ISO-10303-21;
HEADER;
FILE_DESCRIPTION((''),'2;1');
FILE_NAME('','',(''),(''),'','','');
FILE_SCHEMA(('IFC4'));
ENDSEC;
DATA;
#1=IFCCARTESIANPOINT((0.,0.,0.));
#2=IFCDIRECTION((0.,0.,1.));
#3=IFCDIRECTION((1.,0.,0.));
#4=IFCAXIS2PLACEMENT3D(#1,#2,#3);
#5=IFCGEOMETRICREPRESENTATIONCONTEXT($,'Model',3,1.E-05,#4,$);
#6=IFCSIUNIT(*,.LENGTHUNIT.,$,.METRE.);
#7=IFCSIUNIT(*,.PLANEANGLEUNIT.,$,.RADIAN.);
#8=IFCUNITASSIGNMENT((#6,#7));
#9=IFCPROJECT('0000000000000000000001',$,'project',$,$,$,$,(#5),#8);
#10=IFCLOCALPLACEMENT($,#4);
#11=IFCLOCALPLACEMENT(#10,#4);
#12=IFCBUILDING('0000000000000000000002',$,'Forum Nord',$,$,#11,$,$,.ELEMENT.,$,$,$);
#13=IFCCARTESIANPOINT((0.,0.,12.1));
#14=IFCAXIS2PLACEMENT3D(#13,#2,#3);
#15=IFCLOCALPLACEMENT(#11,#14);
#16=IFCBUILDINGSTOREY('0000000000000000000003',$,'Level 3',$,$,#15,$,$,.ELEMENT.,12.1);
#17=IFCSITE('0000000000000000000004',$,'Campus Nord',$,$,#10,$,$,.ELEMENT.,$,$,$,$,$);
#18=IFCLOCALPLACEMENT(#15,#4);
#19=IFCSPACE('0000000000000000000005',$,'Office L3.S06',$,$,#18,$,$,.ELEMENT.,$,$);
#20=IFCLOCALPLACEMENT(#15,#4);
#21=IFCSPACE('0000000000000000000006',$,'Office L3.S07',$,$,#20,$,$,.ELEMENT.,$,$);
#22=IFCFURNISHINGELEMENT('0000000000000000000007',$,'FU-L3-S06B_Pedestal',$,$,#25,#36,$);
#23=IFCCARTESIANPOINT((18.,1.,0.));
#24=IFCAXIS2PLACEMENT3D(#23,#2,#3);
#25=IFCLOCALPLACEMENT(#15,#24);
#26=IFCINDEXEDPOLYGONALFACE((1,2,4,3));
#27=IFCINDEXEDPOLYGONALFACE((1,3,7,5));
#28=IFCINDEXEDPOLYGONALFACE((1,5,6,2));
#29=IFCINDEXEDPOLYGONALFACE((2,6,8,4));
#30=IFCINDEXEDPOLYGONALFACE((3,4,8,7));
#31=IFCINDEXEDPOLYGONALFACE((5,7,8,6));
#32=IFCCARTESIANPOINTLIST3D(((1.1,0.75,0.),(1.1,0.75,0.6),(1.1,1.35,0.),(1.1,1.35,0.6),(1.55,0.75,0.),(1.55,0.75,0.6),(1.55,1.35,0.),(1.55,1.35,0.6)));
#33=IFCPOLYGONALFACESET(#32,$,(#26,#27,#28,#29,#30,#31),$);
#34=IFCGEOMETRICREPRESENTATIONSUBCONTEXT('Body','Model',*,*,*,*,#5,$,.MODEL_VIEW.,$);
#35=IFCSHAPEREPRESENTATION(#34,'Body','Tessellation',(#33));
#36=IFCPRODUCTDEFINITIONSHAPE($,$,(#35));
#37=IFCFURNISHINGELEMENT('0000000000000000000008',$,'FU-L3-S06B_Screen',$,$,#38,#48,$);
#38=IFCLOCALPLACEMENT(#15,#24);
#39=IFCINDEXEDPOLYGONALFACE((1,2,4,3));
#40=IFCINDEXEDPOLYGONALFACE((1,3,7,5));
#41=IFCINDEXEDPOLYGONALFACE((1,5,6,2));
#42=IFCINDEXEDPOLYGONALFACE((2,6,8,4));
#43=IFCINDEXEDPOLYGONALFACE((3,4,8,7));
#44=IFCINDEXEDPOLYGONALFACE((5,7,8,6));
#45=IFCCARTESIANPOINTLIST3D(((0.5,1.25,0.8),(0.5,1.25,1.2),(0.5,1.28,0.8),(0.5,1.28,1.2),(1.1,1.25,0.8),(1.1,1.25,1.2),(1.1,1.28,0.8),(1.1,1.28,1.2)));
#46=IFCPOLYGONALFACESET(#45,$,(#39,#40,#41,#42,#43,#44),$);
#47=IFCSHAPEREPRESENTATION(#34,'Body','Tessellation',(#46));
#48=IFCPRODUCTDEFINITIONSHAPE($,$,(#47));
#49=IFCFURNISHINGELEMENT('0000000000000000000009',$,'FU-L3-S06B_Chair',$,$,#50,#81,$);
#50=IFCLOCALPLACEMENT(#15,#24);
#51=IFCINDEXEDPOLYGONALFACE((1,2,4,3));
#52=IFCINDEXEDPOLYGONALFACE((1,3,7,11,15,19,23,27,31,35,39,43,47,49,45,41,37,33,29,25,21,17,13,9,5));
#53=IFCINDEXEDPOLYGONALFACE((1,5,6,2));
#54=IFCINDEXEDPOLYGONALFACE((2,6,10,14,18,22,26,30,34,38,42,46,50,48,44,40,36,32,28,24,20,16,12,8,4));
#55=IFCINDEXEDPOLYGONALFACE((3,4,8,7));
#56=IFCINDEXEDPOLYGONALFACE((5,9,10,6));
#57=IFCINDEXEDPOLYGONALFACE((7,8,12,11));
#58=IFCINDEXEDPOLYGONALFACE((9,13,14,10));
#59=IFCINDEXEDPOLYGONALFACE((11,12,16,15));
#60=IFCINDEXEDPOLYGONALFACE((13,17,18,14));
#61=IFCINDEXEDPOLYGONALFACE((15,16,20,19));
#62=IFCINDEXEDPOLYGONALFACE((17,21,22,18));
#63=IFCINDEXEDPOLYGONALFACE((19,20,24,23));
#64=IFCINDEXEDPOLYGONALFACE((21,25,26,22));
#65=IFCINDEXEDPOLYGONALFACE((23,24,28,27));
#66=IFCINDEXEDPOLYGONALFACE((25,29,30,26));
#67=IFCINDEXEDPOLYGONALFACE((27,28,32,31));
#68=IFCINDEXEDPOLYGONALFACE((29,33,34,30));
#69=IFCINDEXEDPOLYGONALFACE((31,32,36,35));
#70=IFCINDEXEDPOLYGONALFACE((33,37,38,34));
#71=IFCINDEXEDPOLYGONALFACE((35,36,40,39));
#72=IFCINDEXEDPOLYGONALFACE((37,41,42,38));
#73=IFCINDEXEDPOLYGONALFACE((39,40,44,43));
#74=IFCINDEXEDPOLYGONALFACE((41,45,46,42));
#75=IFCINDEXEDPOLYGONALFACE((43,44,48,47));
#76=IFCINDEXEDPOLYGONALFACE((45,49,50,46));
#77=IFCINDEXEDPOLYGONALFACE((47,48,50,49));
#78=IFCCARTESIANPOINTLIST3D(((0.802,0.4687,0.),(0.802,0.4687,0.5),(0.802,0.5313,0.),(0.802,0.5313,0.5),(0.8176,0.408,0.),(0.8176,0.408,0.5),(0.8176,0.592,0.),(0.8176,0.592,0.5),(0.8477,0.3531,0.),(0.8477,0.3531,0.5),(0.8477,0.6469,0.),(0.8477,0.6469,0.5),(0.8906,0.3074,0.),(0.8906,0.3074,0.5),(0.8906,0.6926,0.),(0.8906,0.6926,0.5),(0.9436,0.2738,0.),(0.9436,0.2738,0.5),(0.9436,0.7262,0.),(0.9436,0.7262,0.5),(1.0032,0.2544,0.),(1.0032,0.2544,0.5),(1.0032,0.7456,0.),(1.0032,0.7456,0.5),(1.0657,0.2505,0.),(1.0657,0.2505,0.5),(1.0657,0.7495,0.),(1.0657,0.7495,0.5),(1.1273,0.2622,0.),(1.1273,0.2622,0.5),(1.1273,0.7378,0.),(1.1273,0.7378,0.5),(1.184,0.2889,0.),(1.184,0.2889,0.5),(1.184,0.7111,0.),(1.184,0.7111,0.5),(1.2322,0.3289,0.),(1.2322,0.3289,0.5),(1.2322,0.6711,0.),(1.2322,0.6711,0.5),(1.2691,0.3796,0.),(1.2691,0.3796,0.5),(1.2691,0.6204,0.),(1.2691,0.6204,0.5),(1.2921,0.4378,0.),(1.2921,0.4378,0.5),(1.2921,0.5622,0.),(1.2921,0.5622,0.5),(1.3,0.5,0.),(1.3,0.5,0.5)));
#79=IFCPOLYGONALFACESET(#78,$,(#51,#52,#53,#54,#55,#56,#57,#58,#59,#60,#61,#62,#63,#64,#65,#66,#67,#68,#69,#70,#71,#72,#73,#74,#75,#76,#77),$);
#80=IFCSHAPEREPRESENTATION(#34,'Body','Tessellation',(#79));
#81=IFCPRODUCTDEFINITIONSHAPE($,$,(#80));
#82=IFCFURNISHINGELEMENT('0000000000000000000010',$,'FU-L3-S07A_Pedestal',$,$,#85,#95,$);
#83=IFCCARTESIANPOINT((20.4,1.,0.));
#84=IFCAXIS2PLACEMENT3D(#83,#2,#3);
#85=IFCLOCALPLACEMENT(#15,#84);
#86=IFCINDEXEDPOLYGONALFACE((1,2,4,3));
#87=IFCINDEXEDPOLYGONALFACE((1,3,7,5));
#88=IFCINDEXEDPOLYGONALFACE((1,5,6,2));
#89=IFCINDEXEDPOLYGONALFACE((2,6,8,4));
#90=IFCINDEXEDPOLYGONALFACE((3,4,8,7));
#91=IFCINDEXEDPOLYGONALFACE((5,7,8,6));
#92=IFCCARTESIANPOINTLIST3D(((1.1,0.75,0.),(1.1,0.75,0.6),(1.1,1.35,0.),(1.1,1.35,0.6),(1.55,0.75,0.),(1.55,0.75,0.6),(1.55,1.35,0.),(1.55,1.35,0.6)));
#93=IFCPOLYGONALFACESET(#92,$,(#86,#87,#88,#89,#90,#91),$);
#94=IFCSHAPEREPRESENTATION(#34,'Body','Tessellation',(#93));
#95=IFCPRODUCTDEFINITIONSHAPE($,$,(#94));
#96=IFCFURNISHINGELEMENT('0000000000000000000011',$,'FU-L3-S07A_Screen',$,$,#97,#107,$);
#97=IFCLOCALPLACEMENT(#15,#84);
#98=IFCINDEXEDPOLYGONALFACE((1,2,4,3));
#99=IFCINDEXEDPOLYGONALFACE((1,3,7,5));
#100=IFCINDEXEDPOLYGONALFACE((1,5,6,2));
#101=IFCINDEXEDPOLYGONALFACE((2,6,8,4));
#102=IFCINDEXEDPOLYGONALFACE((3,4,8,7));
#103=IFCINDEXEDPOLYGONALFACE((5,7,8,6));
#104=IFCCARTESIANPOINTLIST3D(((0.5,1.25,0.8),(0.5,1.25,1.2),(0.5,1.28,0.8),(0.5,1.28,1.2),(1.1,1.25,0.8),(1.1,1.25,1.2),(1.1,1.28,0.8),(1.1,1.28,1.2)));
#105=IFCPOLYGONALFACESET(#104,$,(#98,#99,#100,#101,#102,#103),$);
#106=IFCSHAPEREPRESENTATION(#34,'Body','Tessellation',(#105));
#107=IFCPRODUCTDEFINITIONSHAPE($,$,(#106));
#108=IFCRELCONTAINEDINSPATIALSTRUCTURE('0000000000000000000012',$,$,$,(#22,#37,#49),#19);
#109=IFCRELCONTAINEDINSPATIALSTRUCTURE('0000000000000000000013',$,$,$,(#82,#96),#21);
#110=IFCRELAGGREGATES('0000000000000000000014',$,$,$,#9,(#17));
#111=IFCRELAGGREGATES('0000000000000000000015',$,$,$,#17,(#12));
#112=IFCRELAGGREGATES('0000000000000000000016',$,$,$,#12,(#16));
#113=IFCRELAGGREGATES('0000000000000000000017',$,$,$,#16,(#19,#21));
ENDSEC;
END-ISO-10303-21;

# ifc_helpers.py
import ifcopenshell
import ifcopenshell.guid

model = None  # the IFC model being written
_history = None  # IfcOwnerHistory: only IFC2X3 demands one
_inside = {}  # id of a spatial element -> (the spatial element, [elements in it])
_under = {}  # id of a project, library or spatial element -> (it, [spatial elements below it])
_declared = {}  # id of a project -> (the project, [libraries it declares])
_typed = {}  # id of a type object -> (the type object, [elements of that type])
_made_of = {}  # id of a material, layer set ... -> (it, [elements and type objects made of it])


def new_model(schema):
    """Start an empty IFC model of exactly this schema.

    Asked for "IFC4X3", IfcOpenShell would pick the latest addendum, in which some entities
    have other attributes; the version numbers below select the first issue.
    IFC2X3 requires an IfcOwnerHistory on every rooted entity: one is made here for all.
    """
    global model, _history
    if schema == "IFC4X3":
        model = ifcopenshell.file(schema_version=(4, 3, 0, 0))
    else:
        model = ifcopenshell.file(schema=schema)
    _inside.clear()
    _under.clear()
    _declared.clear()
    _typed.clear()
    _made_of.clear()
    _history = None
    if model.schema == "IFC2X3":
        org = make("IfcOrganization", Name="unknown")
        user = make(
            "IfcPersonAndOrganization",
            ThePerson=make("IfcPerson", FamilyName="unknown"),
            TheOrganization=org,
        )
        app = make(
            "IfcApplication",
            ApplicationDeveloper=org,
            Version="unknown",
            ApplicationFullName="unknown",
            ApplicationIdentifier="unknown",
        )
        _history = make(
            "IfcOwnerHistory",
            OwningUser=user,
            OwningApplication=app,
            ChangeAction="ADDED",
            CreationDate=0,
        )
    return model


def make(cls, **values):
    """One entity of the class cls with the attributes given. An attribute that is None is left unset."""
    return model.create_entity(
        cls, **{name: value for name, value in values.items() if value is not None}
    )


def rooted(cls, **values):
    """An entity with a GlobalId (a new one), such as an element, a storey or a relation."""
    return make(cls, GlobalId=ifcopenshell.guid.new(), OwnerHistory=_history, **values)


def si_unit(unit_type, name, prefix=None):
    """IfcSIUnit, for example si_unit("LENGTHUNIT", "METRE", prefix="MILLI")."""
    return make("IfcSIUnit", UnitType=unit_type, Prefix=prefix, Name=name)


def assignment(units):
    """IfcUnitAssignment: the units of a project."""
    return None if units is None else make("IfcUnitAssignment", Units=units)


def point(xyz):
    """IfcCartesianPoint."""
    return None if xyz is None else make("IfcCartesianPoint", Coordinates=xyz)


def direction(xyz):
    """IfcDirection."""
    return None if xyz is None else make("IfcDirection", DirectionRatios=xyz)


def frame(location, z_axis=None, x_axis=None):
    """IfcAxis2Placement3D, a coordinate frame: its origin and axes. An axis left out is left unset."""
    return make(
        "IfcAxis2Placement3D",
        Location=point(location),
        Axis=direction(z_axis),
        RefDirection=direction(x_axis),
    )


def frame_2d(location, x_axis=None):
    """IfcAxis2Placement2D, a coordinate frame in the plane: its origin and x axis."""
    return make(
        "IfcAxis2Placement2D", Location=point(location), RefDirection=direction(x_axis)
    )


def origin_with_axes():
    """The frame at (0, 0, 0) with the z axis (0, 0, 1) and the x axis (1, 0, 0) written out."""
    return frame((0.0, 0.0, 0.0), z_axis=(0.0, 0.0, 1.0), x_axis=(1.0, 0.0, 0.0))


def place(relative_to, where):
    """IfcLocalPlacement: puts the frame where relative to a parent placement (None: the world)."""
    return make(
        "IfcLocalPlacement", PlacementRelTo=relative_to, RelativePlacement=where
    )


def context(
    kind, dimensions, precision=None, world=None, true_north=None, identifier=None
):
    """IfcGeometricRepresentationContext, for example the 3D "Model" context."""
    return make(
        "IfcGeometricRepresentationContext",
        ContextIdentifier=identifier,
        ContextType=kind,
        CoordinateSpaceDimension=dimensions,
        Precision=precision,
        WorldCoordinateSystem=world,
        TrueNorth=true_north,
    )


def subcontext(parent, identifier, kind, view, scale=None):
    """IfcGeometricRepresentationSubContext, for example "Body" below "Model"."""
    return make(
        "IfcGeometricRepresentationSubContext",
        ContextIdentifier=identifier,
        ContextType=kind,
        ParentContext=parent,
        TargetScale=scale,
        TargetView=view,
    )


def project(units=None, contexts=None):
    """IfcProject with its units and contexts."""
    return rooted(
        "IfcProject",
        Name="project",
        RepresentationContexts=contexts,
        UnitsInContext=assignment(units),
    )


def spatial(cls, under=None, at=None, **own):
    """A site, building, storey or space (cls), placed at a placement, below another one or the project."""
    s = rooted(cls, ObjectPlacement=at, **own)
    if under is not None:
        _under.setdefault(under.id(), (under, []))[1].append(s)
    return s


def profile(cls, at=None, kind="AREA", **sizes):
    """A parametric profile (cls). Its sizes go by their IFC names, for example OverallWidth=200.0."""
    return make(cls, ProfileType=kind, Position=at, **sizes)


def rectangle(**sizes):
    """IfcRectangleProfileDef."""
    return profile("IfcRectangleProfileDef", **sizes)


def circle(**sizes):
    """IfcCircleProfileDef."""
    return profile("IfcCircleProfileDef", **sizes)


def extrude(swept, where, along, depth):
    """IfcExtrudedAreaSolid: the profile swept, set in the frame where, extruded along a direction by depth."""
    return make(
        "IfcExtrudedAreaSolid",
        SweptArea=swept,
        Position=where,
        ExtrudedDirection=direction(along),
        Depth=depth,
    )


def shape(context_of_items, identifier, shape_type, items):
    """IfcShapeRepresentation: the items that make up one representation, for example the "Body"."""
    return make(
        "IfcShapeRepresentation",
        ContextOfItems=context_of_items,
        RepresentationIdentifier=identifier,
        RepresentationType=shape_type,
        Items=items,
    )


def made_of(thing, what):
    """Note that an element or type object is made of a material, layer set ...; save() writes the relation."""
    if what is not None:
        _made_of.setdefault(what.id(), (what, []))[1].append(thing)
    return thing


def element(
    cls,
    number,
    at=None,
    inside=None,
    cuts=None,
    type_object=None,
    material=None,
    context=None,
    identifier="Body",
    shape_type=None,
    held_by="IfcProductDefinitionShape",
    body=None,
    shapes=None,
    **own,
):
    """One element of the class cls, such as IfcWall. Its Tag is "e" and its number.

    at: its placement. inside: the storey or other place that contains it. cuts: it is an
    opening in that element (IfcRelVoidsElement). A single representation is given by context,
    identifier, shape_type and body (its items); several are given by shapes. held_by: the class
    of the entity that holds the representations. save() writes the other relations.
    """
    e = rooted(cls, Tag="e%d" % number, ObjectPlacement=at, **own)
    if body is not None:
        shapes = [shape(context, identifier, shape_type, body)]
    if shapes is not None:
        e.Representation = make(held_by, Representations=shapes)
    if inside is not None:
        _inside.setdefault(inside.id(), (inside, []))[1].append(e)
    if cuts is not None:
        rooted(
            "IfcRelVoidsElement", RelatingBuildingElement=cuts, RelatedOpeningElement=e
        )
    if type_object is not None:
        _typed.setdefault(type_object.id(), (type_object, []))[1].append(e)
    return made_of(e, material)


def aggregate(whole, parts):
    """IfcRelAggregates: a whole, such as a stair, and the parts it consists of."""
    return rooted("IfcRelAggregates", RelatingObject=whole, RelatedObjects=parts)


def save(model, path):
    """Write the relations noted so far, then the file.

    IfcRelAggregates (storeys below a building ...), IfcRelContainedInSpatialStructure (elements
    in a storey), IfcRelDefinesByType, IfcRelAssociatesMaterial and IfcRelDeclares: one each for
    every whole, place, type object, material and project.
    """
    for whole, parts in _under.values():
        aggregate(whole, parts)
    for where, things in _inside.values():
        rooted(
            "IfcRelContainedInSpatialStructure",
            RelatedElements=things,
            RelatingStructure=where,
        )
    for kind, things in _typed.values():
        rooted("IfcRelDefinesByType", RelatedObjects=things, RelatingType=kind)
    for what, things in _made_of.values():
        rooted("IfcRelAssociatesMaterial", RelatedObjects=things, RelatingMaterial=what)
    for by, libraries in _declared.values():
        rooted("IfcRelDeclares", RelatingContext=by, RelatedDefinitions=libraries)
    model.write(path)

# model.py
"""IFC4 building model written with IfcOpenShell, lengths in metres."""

from ifc_helpers import new_model, si_unit, frame, frame_2d, origin_with_axes, place, context, subcontext, project, spatial, rectangle, circle, extrude, element, save


model = new_model("IFC4")

# Units and contexts
model_context = context("Model", 3, precision=1e-05, world=origin_with_axes())
body_context = subcontext(model_context, "Body", "Model", "MODEL_VIEW")
ifc_project = project(units=[si_unit("LENGTHUNIT", "METRE"), si_unit("PLANEANGLEUNIT", "RADIAN")], contexts=[model_context])

# Site, building, storey
site_placement = place(None, origin_with_axes())
site = spatial("IfcSite", under=ifc_project, at=site_placement, Name="Campus Nord", CompositionType="ELEMENT")
building_placement = place(site_placement, origin_with_axes())
building = spatial("IfcBuilding", under=site, at=building_placement, Name="Forum Nord", CompositionType="ELEMENT")
storey_placement = place(building_placement, frame((0.0, 0.0, 12.1), z_axis=(0.0, 0.0, 1.0), x_axis=(1.0, 0.0, 0.0)))
storey = spatial("IfcBuildingStorey", under=building, at=storey_placement, Name="Level 3", CompositionType="ELEMENT", Elevation=12.1)

# Shared definitions
space_1_placement = place(storey_placement, origin_with_axes())
space_1 = spatial("IfcSpace", under=storey, at=space_1_placement, Name="Office L3.S06", CompositionType="ELEMENT")

# Furnishing elements
furnishing_1_placement = place(storey_placement, frame((18.0, 1.0, 0.0), z_axis=(0.0, 0.0, 1.0), x_axis=(1.0, 0.0, 0.0)))
element("IfcFurnishingElement", 1, at=furnishing_1_placement, inside=space_1, Name="FU-L3-S06B_Pedestal", context=body_context, shape_type="SweptSolid", body=[
    extrude(rectangle(XDim=0.45, YDim=0.6, at=frame_2d((1.325, 1.05), x_axis=(1.0, 0.0))), origin_with_axes(), (0.0, 0.0, 1.0), 0.6),
])
furnishing_2_placement = place(storey_placement, frame((18.0, 1.0, 0.0), z_axis=(0.0, 0.0, 1.0), x_axis=(1.0, 0.0, 0.0)))
element("IfcFurnishingElement", 2, at=furnishing_2_placement, inside=space_1, Name="FU-L3-S06B_Screen", context=body_context, shape_type="SweptSolid", body=[
    extrude(rectangle(XDim=0.6, YDim=0.03, at=frame_2d((0.8, 1.265), x_axis=(1.0, 0.0))), frame((0.0, 0.0, 0.8), z_axis=(0.0, 0.0, 1.0), x_axis=(1.0, 0.0, 0.0)), (0.0, 0.0, 1.0), 0.4),
])
furnishing_3_placement = place(storey_placement, frame((18.0, 1.0, 0.0), z_axis=(0.0, 0.0, 1.0), x_axis=(1.0, 0.0, 0.0)))
element("IfcFurnishingElement", 3, at=furnishing_3_placement, inside=space_1, Name="FU-L3-S06B_Chair", context=body_context, shape_type="SweptSolid", body=[
    extrude(circle(Radius=0.25, at=frame_2d((1.05, 0.5), x_axis=(1.0, 0.0))), origin_with_axes(), (0.0, 0.0, 1.0), 0.5),
])

# Shared definitions
space_2_placement = place(storey_placement, origin_with_axes())
space_2 = spatial("IfcSpace", under=storey, at=space_2_placement, Name="Office L3.S07", CompositionType="ELEMENT")

# Furnishing elements
furnishing_4_placement = place(storey_placement, frame((20.4, 1.0, 0.0), z_axis=(0.0, 0.0, 1.0), x_axis=(1.0, 0.0, 0.0)))
element("IfcFurnishingElement", 4, at=furnishing_4_placement, inside=space_2, Name="FU-L3-S07A_Pedestal", context=body_context, shape_type="SweptSolid", body=[
    extrude(rectangle(XDim=0.45, YDim=0.6, at=frame_2d((1.325, 1.05), x_axis=(1.0, 0.0))), origin_with_axes(), (0.0, 0.0, 1.0), 0.6),
])
furnishing_5_placement = place(storey_placement, frame((20.4, 1.0, 0.0), z_axis=(0.0, 0.0, 1.0), x_axis=(1.0, 0.0, 0.0)))
element("IfcFurnishingElement", 5, at=furnishing_5_placement, inside=space_2, Name="FU-L3-S07A_Screen", context=body_context, shape_type="SweptSolid", body=[
    extrude(rectangle(XDim=0.6, YDim=0.03, at=frame_2d((0.8, 1.265), x_axis=(1.0, 0.0))), frame((0.0, 0.0, 0.8), z_axis=(0.0, 0.0, 1.0), x_axis=(1.0, 0.0, 0.0)), (0.0, 0.0, 1.0), 0.4),
])

save(model, "model.ifc")
